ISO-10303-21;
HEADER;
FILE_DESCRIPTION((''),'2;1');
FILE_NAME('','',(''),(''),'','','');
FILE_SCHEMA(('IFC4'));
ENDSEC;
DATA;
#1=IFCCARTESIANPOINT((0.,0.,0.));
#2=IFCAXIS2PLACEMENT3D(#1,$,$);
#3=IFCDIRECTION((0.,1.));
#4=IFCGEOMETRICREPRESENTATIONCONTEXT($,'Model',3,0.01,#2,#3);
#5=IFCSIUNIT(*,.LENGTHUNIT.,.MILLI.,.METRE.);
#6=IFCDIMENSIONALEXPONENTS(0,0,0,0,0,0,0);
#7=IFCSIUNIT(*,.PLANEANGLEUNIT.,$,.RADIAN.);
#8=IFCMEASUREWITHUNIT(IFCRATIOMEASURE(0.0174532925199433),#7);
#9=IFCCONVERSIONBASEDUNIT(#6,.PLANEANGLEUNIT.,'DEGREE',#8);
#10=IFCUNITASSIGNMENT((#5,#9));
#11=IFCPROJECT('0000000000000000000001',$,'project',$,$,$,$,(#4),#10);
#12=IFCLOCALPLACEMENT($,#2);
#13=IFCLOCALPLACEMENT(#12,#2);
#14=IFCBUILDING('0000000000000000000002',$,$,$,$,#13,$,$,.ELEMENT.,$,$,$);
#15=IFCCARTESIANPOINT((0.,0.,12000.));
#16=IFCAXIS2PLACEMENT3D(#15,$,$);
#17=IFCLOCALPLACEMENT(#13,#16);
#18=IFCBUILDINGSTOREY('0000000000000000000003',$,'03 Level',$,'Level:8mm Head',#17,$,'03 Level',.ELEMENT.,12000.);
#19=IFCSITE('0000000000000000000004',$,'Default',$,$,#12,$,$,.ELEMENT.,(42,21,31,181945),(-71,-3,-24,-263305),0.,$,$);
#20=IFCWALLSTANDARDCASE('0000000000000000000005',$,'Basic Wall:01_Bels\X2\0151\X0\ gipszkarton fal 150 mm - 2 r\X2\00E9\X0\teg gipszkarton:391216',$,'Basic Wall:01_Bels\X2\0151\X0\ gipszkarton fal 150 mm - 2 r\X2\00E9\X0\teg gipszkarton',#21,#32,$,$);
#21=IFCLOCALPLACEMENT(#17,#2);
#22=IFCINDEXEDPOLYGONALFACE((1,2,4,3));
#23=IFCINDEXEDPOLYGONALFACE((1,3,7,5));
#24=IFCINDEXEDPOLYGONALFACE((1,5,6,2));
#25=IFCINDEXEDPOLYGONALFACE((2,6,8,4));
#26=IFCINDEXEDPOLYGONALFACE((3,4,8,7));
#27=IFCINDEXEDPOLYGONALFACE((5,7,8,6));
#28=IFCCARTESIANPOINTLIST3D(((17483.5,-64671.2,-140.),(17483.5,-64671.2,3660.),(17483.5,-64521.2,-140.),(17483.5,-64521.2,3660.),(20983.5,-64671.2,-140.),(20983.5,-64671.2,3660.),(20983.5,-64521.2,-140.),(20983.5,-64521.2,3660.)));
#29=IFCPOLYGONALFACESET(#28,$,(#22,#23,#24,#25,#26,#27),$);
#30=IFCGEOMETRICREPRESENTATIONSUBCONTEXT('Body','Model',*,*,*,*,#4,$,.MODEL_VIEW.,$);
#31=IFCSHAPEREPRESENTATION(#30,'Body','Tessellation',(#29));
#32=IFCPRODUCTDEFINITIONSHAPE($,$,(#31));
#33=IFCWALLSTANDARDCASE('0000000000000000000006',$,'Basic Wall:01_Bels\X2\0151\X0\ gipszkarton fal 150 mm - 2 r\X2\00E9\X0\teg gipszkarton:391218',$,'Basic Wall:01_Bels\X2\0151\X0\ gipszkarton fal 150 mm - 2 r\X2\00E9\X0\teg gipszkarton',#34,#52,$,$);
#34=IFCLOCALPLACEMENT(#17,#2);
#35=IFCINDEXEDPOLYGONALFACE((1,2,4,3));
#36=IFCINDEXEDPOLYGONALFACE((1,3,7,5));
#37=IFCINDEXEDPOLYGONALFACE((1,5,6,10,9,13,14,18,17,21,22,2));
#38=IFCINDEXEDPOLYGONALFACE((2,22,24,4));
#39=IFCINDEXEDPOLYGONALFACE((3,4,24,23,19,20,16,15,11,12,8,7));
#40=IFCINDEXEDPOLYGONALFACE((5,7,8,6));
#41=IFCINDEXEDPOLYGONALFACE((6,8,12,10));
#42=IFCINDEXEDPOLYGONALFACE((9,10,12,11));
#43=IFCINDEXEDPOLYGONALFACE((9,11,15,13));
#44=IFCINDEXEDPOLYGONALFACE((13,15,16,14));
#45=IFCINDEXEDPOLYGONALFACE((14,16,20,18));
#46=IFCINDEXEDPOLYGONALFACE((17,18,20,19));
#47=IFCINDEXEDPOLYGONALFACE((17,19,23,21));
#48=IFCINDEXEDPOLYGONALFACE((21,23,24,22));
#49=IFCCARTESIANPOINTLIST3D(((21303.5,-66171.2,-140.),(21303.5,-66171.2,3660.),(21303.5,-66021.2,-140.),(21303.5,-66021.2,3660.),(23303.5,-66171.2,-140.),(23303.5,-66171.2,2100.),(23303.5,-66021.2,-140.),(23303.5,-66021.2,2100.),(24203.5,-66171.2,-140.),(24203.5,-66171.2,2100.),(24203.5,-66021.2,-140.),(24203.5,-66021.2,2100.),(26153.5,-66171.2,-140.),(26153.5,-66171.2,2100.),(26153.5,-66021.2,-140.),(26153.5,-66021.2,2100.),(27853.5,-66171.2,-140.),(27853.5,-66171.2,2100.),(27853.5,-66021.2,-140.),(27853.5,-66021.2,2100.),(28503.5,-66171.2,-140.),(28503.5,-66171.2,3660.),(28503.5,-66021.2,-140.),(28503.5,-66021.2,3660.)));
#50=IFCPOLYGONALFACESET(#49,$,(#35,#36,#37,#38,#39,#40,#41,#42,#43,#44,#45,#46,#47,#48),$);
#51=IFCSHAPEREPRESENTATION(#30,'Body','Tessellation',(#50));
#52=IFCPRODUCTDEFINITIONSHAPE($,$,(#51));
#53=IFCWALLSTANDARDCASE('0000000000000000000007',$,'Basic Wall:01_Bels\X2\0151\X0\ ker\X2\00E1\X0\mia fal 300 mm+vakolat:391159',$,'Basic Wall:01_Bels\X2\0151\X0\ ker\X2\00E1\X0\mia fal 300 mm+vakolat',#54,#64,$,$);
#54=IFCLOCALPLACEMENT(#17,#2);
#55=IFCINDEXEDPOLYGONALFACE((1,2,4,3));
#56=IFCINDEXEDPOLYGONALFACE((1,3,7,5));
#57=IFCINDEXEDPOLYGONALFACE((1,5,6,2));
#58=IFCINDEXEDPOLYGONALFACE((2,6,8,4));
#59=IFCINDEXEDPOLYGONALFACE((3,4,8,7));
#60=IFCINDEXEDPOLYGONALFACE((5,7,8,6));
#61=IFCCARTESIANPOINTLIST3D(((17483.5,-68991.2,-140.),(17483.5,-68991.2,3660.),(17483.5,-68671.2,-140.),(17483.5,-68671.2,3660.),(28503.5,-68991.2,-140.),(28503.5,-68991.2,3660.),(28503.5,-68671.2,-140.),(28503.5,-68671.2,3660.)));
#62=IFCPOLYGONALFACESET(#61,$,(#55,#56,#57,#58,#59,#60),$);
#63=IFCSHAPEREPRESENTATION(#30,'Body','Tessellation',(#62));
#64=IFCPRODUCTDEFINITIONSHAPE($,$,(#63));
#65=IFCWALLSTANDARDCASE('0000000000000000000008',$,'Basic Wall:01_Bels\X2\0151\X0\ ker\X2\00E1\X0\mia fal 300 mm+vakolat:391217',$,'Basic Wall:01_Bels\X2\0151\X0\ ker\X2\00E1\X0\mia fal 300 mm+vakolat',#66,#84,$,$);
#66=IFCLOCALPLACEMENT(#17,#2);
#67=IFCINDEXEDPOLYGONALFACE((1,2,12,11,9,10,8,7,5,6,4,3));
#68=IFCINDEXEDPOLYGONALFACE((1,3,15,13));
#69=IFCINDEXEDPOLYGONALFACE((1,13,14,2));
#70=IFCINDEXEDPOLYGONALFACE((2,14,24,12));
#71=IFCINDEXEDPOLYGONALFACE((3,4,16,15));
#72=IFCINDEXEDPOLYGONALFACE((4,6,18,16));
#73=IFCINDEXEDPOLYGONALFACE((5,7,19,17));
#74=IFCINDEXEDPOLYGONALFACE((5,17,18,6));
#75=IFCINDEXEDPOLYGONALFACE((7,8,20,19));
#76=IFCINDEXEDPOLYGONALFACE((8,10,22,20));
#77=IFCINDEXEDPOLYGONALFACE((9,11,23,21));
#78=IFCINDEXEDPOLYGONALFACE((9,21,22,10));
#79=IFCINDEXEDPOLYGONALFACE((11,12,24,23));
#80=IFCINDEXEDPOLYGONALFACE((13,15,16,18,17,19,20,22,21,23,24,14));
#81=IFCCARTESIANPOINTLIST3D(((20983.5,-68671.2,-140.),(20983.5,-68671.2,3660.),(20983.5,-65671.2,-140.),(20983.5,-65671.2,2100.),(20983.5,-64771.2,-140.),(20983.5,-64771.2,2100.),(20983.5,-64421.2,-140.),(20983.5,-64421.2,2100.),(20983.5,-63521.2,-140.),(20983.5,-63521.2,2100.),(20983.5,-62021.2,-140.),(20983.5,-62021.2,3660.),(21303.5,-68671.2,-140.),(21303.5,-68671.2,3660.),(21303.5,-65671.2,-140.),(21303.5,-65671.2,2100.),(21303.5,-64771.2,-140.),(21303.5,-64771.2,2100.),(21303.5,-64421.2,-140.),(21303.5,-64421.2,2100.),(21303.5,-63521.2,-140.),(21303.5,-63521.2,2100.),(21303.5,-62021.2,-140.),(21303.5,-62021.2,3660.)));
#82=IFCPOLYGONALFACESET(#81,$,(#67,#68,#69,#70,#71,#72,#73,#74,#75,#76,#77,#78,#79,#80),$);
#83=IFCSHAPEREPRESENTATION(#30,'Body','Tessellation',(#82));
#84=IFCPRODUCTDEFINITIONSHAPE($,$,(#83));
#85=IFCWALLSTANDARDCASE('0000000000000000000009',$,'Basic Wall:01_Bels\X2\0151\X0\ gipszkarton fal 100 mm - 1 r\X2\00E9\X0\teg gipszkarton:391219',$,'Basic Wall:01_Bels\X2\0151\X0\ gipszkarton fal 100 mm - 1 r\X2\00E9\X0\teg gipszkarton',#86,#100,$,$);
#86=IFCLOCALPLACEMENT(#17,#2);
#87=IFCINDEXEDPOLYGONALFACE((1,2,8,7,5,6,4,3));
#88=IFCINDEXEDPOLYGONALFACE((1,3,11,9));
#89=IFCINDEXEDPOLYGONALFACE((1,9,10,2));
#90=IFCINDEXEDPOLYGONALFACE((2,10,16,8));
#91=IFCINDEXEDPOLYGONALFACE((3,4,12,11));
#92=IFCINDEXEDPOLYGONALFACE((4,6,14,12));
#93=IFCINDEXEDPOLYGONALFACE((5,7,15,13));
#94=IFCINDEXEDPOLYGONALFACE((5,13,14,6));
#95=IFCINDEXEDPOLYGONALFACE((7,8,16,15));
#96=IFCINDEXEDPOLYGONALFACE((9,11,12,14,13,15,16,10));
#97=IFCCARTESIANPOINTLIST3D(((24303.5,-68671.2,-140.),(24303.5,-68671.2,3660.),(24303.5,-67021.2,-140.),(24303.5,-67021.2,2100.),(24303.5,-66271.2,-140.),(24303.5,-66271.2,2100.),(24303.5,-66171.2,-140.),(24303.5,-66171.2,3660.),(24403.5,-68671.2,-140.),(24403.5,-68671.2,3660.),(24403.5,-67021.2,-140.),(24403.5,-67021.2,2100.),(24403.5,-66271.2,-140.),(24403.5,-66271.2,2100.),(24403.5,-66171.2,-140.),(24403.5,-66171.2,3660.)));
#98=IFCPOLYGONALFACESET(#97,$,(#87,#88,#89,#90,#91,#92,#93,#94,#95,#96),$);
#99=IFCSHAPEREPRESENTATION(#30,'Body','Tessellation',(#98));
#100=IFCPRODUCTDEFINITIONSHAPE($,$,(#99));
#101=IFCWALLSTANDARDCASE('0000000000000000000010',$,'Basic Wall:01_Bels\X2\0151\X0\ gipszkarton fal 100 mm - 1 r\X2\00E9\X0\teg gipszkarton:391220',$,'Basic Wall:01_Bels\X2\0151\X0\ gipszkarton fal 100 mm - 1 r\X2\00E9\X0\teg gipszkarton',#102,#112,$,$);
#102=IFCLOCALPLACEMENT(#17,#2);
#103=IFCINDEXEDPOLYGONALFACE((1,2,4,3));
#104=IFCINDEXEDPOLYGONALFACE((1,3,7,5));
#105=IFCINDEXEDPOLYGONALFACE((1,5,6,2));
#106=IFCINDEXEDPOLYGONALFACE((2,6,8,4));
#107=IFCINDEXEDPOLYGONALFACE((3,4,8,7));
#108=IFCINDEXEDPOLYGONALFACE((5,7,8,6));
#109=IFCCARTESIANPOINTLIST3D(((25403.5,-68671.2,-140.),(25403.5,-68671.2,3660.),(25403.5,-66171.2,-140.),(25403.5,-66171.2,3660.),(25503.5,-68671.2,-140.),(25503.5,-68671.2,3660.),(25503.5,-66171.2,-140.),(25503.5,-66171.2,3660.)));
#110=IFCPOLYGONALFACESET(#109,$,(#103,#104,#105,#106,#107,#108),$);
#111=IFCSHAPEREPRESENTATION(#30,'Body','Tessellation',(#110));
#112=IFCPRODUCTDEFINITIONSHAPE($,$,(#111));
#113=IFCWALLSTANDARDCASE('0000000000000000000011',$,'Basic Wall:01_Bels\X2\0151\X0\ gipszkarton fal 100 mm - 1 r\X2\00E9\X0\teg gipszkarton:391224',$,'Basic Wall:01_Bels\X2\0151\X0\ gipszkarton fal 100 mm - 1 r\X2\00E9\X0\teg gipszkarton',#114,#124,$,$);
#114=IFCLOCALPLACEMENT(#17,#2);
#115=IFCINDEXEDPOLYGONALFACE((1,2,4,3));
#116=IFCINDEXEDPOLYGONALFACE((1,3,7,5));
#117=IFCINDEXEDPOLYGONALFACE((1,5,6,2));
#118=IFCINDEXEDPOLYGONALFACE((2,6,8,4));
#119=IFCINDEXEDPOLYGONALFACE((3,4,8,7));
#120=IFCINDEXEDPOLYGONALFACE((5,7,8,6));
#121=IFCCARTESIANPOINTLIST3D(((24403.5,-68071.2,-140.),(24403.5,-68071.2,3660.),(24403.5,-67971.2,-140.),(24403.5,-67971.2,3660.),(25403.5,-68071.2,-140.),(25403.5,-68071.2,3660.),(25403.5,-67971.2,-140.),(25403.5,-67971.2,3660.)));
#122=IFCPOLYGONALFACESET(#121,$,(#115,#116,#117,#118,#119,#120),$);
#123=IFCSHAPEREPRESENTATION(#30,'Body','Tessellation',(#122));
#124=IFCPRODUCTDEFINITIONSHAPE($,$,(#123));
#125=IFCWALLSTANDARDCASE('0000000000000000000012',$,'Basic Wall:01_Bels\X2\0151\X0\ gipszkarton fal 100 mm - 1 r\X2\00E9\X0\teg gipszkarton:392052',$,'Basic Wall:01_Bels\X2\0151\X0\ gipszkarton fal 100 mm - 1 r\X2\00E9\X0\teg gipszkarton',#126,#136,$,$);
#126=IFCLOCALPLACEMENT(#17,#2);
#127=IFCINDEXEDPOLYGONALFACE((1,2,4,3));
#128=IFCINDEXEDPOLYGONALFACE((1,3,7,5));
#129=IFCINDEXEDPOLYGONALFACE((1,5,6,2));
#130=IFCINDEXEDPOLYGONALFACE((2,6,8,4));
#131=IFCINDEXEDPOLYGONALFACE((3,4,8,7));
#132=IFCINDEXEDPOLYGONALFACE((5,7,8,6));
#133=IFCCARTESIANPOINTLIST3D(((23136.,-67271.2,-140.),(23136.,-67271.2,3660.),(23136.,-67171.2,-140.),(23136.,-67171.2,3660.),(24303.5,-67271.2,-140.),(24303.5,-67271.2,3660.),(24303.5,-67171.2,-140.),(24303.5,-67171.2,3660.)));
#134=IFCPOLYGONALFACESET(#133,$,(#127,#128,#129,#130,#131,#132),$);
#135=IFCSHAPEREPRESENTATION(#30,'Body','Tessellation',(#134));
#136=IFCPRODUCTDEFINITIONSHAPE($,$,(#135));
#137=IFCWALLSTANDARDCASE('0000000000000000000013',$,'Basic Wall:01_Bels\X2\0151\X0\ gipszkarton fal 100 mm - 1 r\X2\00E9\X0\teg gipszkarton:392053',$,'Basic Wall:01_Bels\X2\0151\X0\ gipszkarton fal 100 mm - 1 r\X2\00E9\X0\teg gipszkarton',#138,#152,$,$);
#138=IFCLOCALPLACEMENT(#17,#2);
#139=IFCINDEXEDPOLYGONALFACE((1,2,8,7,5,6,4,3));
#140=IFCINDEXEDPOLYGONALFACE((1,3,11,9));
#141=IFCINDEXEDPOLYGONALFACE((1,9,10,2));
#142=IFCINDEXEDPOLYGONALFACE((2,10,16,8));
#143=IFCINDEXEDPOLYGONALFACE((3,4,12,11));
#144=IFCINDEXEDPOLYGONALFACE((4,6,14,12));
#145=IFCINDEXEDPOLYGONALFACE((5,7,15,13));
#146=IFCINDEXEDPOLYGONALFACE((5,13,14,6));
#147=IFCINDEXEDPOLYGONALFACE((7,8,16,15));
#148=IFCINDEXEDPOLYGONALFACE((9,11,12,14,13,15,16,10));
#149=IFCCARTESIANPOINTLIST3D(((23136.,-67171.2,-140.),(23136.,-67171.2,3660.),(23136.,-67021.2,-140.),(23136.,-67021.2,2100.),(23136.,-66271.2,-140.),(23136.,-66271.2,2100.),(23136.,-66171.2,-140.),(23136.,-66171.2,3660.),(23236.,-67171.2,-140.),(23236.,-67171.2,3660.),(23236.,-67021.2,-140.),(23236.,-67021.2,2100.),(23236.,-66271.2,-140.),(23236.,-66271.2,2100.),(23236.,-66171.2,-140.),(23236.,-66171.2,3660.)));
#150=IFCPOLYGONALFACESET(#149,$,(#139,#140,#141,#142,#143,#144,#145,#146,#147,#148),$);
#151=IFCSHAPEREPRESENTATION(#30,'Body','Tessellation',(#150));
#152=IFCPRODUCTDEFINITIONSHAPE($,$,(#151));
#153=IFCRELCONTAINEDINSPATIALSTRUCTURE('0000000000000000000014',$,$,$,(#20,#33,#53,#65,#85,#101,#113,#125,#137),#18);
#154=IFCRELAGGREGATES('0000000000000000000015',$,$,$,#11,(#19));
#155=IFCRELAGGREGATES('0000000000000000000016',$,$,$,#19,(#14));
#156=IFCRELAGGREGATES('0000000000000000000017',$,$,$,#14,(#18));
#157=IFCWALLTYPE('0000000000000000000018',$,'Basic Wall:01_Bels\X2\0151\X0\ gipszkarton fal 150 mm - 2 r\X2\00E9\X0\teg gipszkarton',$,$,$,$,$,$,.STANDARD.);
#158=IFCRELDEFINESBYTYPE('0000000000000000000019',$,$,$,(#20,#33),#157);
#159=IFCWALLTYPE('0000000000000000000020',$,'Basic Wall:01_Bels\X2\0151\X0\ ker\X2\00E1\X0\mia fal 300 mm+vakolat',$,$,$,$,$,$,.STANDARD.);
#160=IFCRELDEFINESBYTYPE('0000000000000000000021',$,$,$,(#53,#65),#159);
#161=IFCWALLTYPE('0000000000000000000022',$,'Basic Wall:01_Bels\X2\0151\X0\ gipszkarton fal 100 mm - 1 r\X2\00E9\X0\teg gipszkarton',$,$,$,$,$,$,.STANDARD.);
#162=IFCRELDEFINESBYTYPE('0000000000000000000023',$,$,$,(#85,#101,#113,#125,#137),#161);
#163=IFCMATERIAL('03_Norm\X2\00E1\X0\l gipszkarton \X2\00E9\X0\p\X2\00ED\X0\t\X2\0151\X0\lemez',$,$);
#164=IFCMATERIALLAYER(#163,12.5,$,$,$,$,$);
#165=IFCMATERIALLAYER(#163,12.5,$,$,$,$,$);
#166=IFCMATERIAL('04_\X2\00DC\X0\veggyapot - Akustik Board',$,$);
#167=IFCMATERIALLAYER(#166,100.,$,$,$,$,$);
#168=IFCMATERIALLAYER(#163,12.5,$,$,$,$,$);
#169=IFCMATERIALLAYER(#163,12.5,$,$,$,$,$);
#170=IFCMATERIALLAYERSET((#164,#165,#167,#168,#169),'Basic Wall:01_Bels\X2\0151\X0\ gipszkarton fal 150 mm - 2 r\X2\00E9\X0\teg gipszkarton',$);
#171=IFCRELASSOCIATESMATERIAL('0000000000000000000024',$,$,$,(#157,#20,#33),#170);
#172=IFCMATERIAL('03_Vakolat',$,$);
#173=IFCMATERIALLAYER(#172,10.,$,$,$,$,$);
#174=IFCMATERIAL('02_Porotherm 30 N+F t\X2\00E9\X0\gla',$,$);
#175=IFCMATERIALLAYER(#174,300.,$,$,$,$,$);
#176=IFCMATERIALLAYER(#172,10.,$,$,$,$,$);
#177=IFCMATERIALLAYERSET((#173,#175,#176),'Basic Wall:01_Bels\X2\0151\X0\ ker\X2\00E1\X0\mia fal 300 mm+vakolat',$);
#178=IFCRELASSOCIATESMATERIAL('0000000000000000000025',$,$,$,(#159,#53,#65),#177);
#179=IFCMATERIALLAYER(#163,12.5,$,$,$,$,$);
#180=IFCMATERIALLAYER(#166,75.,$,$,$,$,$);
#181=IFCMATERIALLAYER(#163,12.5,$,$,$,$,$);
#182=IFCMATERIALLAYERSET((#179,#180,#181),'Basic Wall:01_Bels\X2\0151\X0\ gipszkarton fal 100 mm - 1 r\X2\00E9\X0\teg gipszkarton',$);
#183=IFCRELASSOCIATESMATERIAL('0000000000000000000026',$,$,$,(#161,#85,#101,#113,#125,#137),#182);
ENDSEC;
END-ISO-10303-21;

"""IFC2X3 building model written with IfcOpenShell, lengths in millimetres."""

from ifc_helpers import new_model, entity, si_unit, converted_unit, direction, frame, frame_2d, origin, place, context, subcontext, project, spatial, rectangle, extrude, material, layer, layer_set, layer_usage, type_object, element, save


model = new_model("IFC2X3")

# Units and contexts
model_context = context("Model", 3, precision=0.01, world=origin(), true_north=direction((0.0, 1.0)))
body_context = subcontext(model_context, "Body", "Model", "MODEL_VIEW")
ifc_project = project(units=[si_unit("LENGTHUNIT", "METRE", prefix="MILLI"), converted_unit("PLANEANGLEUNIT", "DEGREE", entity("IfcRatioMeasure", 0.0174532925199433), si_unit("PLANEANGLEUNIT", "RADIAN"), dimensions=[0, 0, 0, 0, 0, 0, 0])], contexts=[model_context])

# Site, building, storey
site_placement = place(None, origin())
site = spatial("IfcSite", under=ifc_project, at=site_placement, Name="Default", CompositionType="ELEMENT", RefLatitude=(42, 21, 31, 181945), RefLongitude=(-71, -3, -24, -263305), RefElevation=0.0)
building_placement = place(site_placement, origin())
building = spatial("IfcBuilding", under=site, at=building_placement, CompositionType="ELEMENT")
storey_placement = place(building_placement, frame((0.0, 0.0, 12000.0)))
storey = spatial("IfcBuildingStorey", under=building, at=storey_placement, Name="03 Level", ObjectType="Level:8mm Head", LongName="03 Level", CompositionType="ELEMENT", Elevation=12000.0)

# Wall
ifc_material_1 = material(Name="03_Normál gipszkarton építőlemez")
ifc_layer_1 = layer(ifc_material_1, 12.5)
ifc_layer_2 = layer(ifc_material_1, 12.5)
ifc_material_2 = material(Name="04_Üveggyapot - Akustik Board")
ifc_layer_3 = layer(ifc_material_2, 100.0)
ifc_layer_4 = layer(ifc_material_1, 12.5)
ifc_layer_5 = layer(ifc_material_1, 12.5)
ifc_layer_set_1 = layer_set([ifc_layer_1, ifc_layer_2, ifc_layer_3, ifc_layer_4, ifc_layer_5], Name="Basic Wall:01_Belső gipszkarton fal 150 mm - 2 réteg gipszkarton")
ifc_layer_usage_1 = layer_usage(ifc_layer_set_1, "AXIS2", "POSITIVE", -75.0)
wall_type_1 = type_object("IfcWallType", Name="Basic Wall:01_Belső gipszkarton fal 150 mm - 2 réteg gipszkarton", PredefinedType="STANDARD", material=ifc_layer_set_1)
wall_1_placement = place(storey_placement, frame((17483.5, -64596.2, -140.0)))
element("IfcWallStandardCase", 1, at=wall_1_placement, inside=storey, type_object=wall_type_1, material=ifc_layer_usage_1, Name="Basic Wall:01_Belső gipszkarton fal 150 mm - 2 réteg gipszkarton:391216", ObjectType="Basic Wall:01_Belső gipszkarton fal 150 mm - 2 réteg gipszkarton", context=body_context, shape_type="SweptSolid", body=[
    extrude(rectangle(XDim=3500.0, YDim=150.0, at=frame_2d((1750.0, 0.0), x_axis=(-1.0, 0.0))), origin(), (0.0, 0.0, 1.0), 3800.0),
])

# Wall, openings
ifc_layer_usage_2 = layer_usage(ifc_layer_set_1, "AXIS2", "POSITIVE", -75.0)
wall_2_placement = place(storey_placement, frame((21303.5, -66096.2, -140.0)))
wall_2 = element("IfcWallStandardCase", 2, at=wall_2_placement, inside=storey, type_object=wall_type_1, material=ifc_layer_usage_2, Name="Basic Wall:01_Belső gipszkarton fal 150 mm - 2 réteg gipszkarton:391218", ObjectType="Basic Wall:01_Belső gipszkarton fal 150 mm - 2 réteg gipszkarton", context=body_context, shape_type="SweptSolid", body=[
    extrude(rectangle(XDim=7200.0, YDim=150.0, at=frame_2d((3600.0, 0.0), x_axis=(-1.0, 0.0))), origin(), (0.0, 0.0, 1.0), 3800.0),
])
opening_1_placement = place(wall_2_placement, frame((4850.0, -75.0, 0.0)))
element("IfcOpeningElement", 3, at=opening_1_placement, cuts=wall_2, ObjectType="Opening", context=body_context, shape_type="SweptSolid", body=[
    extrude(rectangle(XDim=2240.0, YDim=1700.0, at=frame_2d((0.0, 0.0), x_axis=(1.0, 0.0))), frame((850.0, 0.0, 1120.0), z_axis=(0.0, 1.0, 0.0), x_axis=(0.0, 0.0, -1.0)), (0.0, 0.0, 1.0), 150.0),
])
opening_2_placement = place(wall_2_placement, frame((2000.0, -1599.0, 0.0)))
element("IfcOpeningElement", 4, at=opening_2_placement, cuts=wall_2, ObjectType="Opening", context=body_context, shape_type="SweptSolid", body=[
    extrude(rectangle(XDim=2240.0, YDim=900.0, at=frame_2d((0.0, 0.0), x_axis=(0.0, 1.0))), frame((450.0, 0.0, 1120.0), z_axis=(0.0, 1.0, 0.0), x_axis=(-1.0, 0.0, 0.0)), (0.0, 0.0, 1.0), 3048.0),
])

# Wall
ifc_material_3 = material(Name="03_Vakolat")
ifc_layer_6 = layer(ifc_material_3, 10.0)
ifc_material_4 = material(Name="02_Porotherm 30 N+F tégla")
ifc_layer_7 = layer(ifc_material_4, 300.0)
ifc_layer_8 = layer(ifc_material_3, 10.0)
ifc_layer_set_2 = layer_set([ifc_layer_6, ifc_layer_7, ifc_layer_8], Name="Basic Wall:01_Belső kerámia fal 300 mm+vakolat")
ifc_layer_usage_3 = layer_usage(ifc_layer_set_2, "AXIS2", "NEGATIVE", 160.0)
wall_type_2 = type_object("IfcWallType", Name="Basic Wall:01_Belső kerámia fal 300 mm+vakolat", PredefinedType="STANDARD", material=ifc_layer_set_2)
wall_3_placement = place(storey_placement, frame((17483.5, -68831.2, -140.0)))
element("IfcWallStandardCase", 5, at=wall_3_placement, inside=storey, type_object=wall_type_2, material=ifc_layer_usage_3, Name="Basic Wall:01_Belső kerámia fal 300 mm+vakolat:391159", ObjectType="Basic Wall:01_Belső kerámia fal 300 mm+vakolat", context=body_context, shape_type="SweptSolid", body=[
    extrude(rectangle(XDim=11020.0, YDim=320.0, at=frame_2d((5510.0, 0.0), x_axis=(-1.0, 0.0))), origin(), (0.0, 0.0, 1.0), 3800.0),
])

# Wall, openings
ifc_layer_usage_4 = layer_usage(ifc_layer_set_2, "AXIS2", "POSITIVE", -160.0)
wall_4_placement = place(storey_placement, frame((21143.5, -68671.2, -140.0), z_axis=(0.0, 0.0, 1.0), x_axis=(0.0, 1.0, 0.0)))
wall_4 = element("IfcWallStandardCase", 6, at=wall_4_placement, inside=storey, type_object=wall_type_2, material=ifc_layer_usage_4, Name="Basic Wall:01_Belső kerámia fal 300 mm+vakolat:391217", ObjectType="Basic Wall:01_Belső kerámia fal 300 mm+vakolat", context=body_context, shape_type="SweptSolid", body=[
    extrude(rectangle(XDim=6650.0, YDim=320.0, at=frame_2d((3325.0, 0.0), x_axis=(-1.0, 0.0))), origin(), (0.0, 0.0, 1.0), 3800.0),
])
opening_3_placement = place(wall_4_placement, frame((3000.0, 1364.0, 0.0), z_axis=(0.0, 0.0, 1.0), x_axis=(0.0, -1.0, 0.0)))
element("IfcOpeningElement", 7, at=opening_3_placement, cuts=wall_4, ObjectType="Opening", context=body_context, shape_type="SweptSolid", body=[
    extrude(rectangle(XDim=2240.0, YDim=900.0, at=frame_2d((0.0, 0.0), x_axis=(1.0, 0.0))), frame((3048.0, 450.0, 1120.0), z_axis=(-1.0, 0.0, 0.0), x_axis=(0.0, 0.0, 1.0)), (0.0, 0.0, 1.0), 3048.0),
])
opening_4_placement = place(wall_4_placement, frame((4250.0, 1364.0, 0.0), z_axis=(0.0, 0.0, 1.0), x_axis=(0.0, -1.0, 0.0)))
element("IfcOpeningElement", 8, at=opening_4_placement, cuts=wall_4, ObjectType="Opening", context=body_context, shape_type="SweptSolid", body=[
    extrude(rectangle(XDim=2240.0, YDim=900.0, at=frame_2d((0.0, 0.0), x_axis=(0.0, 1.0))), frame((3048.0, 450.0, 1120.0), z_axis=(-1.0, 0.0, 0.0), x_axis=(0.0, -1.0, 0.0)), (0.0, 0.0, 1.0), 3048.0),
])

# Wall, opening
ifc_layer_9 = layer(ifc_material_1, 12.5)
ifc_layer_10 = layer(ifc_material_2, 75.0)
ifc_layer_11 = layer(ifc_material_1, 12.5)
ifc_layer_set_3 = layer_set([ifc_layer_9, ifc_layer_10, ifc_layer_11], Name="Basic Wall:01_Belső gipszkarton fal 100 mm - 1 réteg gipszkarton")
ifc_layer_usage_5 = layer_usage(ifc_layer_set_3, "AXIS2", "POSITIVE", -50.0)
wall_type_3 = type_object("IfcWallType", Name="Basic Wall:01_Belső gipszkarton fal 100 mm - 1 réteg gipszkarton", PredefinedType="STANDARD", material=ifc_layer_set_3)
wall_5_placement = place(storey_placement, frame((24353.5, -66171.2, -140.0), z_axis=(0.0, 0.0, 1.0), x_axis=(0.0, -1.0, 0.0)))
wall_5 = element("IfcWallStandardCase", 9, at=wall_5_placement, inside=storey, type_object=wall_type_3, material=ifc_layer_usage_5, Name="Basic Wall:01_Belső gipszkarton fal 100 mm - 1 réteg gipszkarton:391219", ObjectType="Basic Wall:01_Belső gipszkarton fal 100 mm - 1 réteg gipszkarton", context=body_context, shape_type="SweptSolid", body=[
    extrude(rectangle(XDim=2500.0, YDim=100.0, at=frame_2d((1250.0, 0.0), x_axis=(-1.0, 0.0))), origin(), (0.0, 0.0, 1.0), 3800.0),
])
opening_5_placement = place(wall_5_placement, frame((850.0, -1574.0, 0.0), z_axis=(0.0, 0.0, 1.0), x_axis=(0.0, 1.0, 0.0)))
element("IfcOpeningElement", 10, at=opening_5_placement, cuts=wall_5, ObjectType="Opening", context=body_context, shape_type="SweptSolid", body=[
    extrude(rectangle(XDim=2240.0, YDim=750.0, at=frame_2d((0.0, 0.0), x_axis=(0.0, 1.0))), frame((0.0, 375.0, 1120.0), z_axis=(1.0, 0.0, 0.0), x_axis=(0.0, 1.0, 0.0)), (0.0, 0.0, 1.0), 3048.0),
])

# Walls
ifc_layer_usage_6 = layer_usage(ifc_layer_set_3, "AXIS2", "POSITIVE", -50.0)
wall_6_placement = place(storey_placement, frame((25453.5, -66171.2, -140.0), z_axis=(0.0, 0.0, 1.0), x_axis=(0.0, -1.0, 0.0)))
element("IfcWallStandardCase", 11, at=wall_6_placement, inside=storey, type_object=wall_type_3, material=ifc_layer_usage_6, Name="Basic Wall:01_Belső gipszkarton fal 100 mm - 1 réteg gipszkarton:391220", ObjectType="Basic Wall:01_Belső gipszkarton fal 100 mm - 1 réteg gipszkarton", context=body_context, shape_type="SweptSolid", body=[
    extrude(rectangle(XDim=2500.0, YDim=100.0, at=frame_2d((1250.0, 0.0), x_axis=(-1.0, 0.0))), origin(), (0.0, 0.0, 1.0), 3800.0),
])
ifc_layer_usage_7 = layer_usage(ifc_layer_set_3, "AXIS2", "POSITIVE", -50.0)
wall_7_placement = place(storey_placement, frame((24403.5, -68021.2, -140.0)))
element("IfcWallStandardCase", 12, at=wall_7_placement, inside=storey, type_object=wall_type_3, material=ifc_layer_usage_7, Name="Basic Wall:01_Belső gipszkarton fal 100 mm - 1 réteg gipszkarton:391224", ObjectType="Basic Wall:01_Belső gipszkarton fal 100 mm - 1 réteg gipszkarton", context=body_context, shape_type="SweptSolid", body=[
    extrude(rectangle(XDim=1000.0, YDim=100.0, at=frame_2d((500.0, 0.0), x_axis=(-1.0, 0.0))), origin(), (0.0, 0.0, 1.0), 3800.0),
])
ifc_layer_usage_8 = layer_usage(ifc_layer_set_3, "AXIS2", "POSITIVE", -50.0)
wall_8_placement = place(storey_placement, frame((24303.5, -67221.2, -140.0), z_axis=(0.0, 0.0, 1.0), x_axis=(-1.0, 0.0, 0.0)))
element("IfcWallStandardCase", 13, at=wall_8_placement, inside=storey, type_object=wall_type_3, material=ifc_layer_usage_8, Name="Basic Wall:01_Belső gipszkarton fal 100 mm - 1 réteg gipszkarton:392052", ObjectType="Basic Wall:01_Belső gipszkarton fal 100 mm - 1 réteg gipszkarton", context=body_context, shape_type="SweptSolid", body=[
    extrude(rectangle(XDim=1167.5, YDim=100.0, at=frame_2d((583.8, 0.0), x_axis=(-1.0, 0.0))), origin(), (0.0, 0.0, 1.0), 3800.0),
])

# Wall, opening
ifc_layer_usage_9 = layer_usage(ifc_layer_set_3, "AXIS2", "POSITIVE", -50.0)
wall_9_placement = place(storey_placement, frame((23186.0, -67171.2, -140.0), z_axis=(0.0, 0.0, 1.0), x_axis=(0.0, 1.0, 0.0)))
wall_9 = element("IfcWallStandardCase", 14, at=wall_9_placement, inside=storey, type_object=wall_type_3, material=ifc_layer_usage_9, Name="Basic Wall:01_Belső gipszkarton fal 100 mm - 1 réteg gipszkarton:392053", ObjectType="Basic Wall:01_Belső gipszkarton fal 100 mm - 1 réteg gipszkarton", context=body_context, shape_type="SweptSolid", body=[
    extrude(rectangle(XDim=1000.0, YDim=100.0, at=frame_2d((500.0, 0.0), x_axis=(-1.0, 0.0))), origin(), (0.0, 0.0, 1.0), 3800.0),
])
opening_6_placement = place(wall_9_placement, frame((150.0, 1474.0, 0.0), z_axis=(0.0, 0.0, 1.0), x_axis=(0.0, -1.0, 0.0)))
element("IfcOpeningElement", 15, at=opening_6_placement, cuts=wall_9, ObjectType="Opening", context=body_context, shape_type="SweptSolid", body=[
    extrude(rectangle(XDim=2240.0, YDim=750.0, at=frame_2d((0.0, 0.0), x_axis=(1.0, 0.0))), frame((3048.0, 375.0, 1120.0), z_axis=(-1.0, 0.0, 0.0), x_axis=(0.0, 0.0, 1.0)), (0.0, 0.0, 1.0), 3048.0),
])

save(model, "model.ifc")
